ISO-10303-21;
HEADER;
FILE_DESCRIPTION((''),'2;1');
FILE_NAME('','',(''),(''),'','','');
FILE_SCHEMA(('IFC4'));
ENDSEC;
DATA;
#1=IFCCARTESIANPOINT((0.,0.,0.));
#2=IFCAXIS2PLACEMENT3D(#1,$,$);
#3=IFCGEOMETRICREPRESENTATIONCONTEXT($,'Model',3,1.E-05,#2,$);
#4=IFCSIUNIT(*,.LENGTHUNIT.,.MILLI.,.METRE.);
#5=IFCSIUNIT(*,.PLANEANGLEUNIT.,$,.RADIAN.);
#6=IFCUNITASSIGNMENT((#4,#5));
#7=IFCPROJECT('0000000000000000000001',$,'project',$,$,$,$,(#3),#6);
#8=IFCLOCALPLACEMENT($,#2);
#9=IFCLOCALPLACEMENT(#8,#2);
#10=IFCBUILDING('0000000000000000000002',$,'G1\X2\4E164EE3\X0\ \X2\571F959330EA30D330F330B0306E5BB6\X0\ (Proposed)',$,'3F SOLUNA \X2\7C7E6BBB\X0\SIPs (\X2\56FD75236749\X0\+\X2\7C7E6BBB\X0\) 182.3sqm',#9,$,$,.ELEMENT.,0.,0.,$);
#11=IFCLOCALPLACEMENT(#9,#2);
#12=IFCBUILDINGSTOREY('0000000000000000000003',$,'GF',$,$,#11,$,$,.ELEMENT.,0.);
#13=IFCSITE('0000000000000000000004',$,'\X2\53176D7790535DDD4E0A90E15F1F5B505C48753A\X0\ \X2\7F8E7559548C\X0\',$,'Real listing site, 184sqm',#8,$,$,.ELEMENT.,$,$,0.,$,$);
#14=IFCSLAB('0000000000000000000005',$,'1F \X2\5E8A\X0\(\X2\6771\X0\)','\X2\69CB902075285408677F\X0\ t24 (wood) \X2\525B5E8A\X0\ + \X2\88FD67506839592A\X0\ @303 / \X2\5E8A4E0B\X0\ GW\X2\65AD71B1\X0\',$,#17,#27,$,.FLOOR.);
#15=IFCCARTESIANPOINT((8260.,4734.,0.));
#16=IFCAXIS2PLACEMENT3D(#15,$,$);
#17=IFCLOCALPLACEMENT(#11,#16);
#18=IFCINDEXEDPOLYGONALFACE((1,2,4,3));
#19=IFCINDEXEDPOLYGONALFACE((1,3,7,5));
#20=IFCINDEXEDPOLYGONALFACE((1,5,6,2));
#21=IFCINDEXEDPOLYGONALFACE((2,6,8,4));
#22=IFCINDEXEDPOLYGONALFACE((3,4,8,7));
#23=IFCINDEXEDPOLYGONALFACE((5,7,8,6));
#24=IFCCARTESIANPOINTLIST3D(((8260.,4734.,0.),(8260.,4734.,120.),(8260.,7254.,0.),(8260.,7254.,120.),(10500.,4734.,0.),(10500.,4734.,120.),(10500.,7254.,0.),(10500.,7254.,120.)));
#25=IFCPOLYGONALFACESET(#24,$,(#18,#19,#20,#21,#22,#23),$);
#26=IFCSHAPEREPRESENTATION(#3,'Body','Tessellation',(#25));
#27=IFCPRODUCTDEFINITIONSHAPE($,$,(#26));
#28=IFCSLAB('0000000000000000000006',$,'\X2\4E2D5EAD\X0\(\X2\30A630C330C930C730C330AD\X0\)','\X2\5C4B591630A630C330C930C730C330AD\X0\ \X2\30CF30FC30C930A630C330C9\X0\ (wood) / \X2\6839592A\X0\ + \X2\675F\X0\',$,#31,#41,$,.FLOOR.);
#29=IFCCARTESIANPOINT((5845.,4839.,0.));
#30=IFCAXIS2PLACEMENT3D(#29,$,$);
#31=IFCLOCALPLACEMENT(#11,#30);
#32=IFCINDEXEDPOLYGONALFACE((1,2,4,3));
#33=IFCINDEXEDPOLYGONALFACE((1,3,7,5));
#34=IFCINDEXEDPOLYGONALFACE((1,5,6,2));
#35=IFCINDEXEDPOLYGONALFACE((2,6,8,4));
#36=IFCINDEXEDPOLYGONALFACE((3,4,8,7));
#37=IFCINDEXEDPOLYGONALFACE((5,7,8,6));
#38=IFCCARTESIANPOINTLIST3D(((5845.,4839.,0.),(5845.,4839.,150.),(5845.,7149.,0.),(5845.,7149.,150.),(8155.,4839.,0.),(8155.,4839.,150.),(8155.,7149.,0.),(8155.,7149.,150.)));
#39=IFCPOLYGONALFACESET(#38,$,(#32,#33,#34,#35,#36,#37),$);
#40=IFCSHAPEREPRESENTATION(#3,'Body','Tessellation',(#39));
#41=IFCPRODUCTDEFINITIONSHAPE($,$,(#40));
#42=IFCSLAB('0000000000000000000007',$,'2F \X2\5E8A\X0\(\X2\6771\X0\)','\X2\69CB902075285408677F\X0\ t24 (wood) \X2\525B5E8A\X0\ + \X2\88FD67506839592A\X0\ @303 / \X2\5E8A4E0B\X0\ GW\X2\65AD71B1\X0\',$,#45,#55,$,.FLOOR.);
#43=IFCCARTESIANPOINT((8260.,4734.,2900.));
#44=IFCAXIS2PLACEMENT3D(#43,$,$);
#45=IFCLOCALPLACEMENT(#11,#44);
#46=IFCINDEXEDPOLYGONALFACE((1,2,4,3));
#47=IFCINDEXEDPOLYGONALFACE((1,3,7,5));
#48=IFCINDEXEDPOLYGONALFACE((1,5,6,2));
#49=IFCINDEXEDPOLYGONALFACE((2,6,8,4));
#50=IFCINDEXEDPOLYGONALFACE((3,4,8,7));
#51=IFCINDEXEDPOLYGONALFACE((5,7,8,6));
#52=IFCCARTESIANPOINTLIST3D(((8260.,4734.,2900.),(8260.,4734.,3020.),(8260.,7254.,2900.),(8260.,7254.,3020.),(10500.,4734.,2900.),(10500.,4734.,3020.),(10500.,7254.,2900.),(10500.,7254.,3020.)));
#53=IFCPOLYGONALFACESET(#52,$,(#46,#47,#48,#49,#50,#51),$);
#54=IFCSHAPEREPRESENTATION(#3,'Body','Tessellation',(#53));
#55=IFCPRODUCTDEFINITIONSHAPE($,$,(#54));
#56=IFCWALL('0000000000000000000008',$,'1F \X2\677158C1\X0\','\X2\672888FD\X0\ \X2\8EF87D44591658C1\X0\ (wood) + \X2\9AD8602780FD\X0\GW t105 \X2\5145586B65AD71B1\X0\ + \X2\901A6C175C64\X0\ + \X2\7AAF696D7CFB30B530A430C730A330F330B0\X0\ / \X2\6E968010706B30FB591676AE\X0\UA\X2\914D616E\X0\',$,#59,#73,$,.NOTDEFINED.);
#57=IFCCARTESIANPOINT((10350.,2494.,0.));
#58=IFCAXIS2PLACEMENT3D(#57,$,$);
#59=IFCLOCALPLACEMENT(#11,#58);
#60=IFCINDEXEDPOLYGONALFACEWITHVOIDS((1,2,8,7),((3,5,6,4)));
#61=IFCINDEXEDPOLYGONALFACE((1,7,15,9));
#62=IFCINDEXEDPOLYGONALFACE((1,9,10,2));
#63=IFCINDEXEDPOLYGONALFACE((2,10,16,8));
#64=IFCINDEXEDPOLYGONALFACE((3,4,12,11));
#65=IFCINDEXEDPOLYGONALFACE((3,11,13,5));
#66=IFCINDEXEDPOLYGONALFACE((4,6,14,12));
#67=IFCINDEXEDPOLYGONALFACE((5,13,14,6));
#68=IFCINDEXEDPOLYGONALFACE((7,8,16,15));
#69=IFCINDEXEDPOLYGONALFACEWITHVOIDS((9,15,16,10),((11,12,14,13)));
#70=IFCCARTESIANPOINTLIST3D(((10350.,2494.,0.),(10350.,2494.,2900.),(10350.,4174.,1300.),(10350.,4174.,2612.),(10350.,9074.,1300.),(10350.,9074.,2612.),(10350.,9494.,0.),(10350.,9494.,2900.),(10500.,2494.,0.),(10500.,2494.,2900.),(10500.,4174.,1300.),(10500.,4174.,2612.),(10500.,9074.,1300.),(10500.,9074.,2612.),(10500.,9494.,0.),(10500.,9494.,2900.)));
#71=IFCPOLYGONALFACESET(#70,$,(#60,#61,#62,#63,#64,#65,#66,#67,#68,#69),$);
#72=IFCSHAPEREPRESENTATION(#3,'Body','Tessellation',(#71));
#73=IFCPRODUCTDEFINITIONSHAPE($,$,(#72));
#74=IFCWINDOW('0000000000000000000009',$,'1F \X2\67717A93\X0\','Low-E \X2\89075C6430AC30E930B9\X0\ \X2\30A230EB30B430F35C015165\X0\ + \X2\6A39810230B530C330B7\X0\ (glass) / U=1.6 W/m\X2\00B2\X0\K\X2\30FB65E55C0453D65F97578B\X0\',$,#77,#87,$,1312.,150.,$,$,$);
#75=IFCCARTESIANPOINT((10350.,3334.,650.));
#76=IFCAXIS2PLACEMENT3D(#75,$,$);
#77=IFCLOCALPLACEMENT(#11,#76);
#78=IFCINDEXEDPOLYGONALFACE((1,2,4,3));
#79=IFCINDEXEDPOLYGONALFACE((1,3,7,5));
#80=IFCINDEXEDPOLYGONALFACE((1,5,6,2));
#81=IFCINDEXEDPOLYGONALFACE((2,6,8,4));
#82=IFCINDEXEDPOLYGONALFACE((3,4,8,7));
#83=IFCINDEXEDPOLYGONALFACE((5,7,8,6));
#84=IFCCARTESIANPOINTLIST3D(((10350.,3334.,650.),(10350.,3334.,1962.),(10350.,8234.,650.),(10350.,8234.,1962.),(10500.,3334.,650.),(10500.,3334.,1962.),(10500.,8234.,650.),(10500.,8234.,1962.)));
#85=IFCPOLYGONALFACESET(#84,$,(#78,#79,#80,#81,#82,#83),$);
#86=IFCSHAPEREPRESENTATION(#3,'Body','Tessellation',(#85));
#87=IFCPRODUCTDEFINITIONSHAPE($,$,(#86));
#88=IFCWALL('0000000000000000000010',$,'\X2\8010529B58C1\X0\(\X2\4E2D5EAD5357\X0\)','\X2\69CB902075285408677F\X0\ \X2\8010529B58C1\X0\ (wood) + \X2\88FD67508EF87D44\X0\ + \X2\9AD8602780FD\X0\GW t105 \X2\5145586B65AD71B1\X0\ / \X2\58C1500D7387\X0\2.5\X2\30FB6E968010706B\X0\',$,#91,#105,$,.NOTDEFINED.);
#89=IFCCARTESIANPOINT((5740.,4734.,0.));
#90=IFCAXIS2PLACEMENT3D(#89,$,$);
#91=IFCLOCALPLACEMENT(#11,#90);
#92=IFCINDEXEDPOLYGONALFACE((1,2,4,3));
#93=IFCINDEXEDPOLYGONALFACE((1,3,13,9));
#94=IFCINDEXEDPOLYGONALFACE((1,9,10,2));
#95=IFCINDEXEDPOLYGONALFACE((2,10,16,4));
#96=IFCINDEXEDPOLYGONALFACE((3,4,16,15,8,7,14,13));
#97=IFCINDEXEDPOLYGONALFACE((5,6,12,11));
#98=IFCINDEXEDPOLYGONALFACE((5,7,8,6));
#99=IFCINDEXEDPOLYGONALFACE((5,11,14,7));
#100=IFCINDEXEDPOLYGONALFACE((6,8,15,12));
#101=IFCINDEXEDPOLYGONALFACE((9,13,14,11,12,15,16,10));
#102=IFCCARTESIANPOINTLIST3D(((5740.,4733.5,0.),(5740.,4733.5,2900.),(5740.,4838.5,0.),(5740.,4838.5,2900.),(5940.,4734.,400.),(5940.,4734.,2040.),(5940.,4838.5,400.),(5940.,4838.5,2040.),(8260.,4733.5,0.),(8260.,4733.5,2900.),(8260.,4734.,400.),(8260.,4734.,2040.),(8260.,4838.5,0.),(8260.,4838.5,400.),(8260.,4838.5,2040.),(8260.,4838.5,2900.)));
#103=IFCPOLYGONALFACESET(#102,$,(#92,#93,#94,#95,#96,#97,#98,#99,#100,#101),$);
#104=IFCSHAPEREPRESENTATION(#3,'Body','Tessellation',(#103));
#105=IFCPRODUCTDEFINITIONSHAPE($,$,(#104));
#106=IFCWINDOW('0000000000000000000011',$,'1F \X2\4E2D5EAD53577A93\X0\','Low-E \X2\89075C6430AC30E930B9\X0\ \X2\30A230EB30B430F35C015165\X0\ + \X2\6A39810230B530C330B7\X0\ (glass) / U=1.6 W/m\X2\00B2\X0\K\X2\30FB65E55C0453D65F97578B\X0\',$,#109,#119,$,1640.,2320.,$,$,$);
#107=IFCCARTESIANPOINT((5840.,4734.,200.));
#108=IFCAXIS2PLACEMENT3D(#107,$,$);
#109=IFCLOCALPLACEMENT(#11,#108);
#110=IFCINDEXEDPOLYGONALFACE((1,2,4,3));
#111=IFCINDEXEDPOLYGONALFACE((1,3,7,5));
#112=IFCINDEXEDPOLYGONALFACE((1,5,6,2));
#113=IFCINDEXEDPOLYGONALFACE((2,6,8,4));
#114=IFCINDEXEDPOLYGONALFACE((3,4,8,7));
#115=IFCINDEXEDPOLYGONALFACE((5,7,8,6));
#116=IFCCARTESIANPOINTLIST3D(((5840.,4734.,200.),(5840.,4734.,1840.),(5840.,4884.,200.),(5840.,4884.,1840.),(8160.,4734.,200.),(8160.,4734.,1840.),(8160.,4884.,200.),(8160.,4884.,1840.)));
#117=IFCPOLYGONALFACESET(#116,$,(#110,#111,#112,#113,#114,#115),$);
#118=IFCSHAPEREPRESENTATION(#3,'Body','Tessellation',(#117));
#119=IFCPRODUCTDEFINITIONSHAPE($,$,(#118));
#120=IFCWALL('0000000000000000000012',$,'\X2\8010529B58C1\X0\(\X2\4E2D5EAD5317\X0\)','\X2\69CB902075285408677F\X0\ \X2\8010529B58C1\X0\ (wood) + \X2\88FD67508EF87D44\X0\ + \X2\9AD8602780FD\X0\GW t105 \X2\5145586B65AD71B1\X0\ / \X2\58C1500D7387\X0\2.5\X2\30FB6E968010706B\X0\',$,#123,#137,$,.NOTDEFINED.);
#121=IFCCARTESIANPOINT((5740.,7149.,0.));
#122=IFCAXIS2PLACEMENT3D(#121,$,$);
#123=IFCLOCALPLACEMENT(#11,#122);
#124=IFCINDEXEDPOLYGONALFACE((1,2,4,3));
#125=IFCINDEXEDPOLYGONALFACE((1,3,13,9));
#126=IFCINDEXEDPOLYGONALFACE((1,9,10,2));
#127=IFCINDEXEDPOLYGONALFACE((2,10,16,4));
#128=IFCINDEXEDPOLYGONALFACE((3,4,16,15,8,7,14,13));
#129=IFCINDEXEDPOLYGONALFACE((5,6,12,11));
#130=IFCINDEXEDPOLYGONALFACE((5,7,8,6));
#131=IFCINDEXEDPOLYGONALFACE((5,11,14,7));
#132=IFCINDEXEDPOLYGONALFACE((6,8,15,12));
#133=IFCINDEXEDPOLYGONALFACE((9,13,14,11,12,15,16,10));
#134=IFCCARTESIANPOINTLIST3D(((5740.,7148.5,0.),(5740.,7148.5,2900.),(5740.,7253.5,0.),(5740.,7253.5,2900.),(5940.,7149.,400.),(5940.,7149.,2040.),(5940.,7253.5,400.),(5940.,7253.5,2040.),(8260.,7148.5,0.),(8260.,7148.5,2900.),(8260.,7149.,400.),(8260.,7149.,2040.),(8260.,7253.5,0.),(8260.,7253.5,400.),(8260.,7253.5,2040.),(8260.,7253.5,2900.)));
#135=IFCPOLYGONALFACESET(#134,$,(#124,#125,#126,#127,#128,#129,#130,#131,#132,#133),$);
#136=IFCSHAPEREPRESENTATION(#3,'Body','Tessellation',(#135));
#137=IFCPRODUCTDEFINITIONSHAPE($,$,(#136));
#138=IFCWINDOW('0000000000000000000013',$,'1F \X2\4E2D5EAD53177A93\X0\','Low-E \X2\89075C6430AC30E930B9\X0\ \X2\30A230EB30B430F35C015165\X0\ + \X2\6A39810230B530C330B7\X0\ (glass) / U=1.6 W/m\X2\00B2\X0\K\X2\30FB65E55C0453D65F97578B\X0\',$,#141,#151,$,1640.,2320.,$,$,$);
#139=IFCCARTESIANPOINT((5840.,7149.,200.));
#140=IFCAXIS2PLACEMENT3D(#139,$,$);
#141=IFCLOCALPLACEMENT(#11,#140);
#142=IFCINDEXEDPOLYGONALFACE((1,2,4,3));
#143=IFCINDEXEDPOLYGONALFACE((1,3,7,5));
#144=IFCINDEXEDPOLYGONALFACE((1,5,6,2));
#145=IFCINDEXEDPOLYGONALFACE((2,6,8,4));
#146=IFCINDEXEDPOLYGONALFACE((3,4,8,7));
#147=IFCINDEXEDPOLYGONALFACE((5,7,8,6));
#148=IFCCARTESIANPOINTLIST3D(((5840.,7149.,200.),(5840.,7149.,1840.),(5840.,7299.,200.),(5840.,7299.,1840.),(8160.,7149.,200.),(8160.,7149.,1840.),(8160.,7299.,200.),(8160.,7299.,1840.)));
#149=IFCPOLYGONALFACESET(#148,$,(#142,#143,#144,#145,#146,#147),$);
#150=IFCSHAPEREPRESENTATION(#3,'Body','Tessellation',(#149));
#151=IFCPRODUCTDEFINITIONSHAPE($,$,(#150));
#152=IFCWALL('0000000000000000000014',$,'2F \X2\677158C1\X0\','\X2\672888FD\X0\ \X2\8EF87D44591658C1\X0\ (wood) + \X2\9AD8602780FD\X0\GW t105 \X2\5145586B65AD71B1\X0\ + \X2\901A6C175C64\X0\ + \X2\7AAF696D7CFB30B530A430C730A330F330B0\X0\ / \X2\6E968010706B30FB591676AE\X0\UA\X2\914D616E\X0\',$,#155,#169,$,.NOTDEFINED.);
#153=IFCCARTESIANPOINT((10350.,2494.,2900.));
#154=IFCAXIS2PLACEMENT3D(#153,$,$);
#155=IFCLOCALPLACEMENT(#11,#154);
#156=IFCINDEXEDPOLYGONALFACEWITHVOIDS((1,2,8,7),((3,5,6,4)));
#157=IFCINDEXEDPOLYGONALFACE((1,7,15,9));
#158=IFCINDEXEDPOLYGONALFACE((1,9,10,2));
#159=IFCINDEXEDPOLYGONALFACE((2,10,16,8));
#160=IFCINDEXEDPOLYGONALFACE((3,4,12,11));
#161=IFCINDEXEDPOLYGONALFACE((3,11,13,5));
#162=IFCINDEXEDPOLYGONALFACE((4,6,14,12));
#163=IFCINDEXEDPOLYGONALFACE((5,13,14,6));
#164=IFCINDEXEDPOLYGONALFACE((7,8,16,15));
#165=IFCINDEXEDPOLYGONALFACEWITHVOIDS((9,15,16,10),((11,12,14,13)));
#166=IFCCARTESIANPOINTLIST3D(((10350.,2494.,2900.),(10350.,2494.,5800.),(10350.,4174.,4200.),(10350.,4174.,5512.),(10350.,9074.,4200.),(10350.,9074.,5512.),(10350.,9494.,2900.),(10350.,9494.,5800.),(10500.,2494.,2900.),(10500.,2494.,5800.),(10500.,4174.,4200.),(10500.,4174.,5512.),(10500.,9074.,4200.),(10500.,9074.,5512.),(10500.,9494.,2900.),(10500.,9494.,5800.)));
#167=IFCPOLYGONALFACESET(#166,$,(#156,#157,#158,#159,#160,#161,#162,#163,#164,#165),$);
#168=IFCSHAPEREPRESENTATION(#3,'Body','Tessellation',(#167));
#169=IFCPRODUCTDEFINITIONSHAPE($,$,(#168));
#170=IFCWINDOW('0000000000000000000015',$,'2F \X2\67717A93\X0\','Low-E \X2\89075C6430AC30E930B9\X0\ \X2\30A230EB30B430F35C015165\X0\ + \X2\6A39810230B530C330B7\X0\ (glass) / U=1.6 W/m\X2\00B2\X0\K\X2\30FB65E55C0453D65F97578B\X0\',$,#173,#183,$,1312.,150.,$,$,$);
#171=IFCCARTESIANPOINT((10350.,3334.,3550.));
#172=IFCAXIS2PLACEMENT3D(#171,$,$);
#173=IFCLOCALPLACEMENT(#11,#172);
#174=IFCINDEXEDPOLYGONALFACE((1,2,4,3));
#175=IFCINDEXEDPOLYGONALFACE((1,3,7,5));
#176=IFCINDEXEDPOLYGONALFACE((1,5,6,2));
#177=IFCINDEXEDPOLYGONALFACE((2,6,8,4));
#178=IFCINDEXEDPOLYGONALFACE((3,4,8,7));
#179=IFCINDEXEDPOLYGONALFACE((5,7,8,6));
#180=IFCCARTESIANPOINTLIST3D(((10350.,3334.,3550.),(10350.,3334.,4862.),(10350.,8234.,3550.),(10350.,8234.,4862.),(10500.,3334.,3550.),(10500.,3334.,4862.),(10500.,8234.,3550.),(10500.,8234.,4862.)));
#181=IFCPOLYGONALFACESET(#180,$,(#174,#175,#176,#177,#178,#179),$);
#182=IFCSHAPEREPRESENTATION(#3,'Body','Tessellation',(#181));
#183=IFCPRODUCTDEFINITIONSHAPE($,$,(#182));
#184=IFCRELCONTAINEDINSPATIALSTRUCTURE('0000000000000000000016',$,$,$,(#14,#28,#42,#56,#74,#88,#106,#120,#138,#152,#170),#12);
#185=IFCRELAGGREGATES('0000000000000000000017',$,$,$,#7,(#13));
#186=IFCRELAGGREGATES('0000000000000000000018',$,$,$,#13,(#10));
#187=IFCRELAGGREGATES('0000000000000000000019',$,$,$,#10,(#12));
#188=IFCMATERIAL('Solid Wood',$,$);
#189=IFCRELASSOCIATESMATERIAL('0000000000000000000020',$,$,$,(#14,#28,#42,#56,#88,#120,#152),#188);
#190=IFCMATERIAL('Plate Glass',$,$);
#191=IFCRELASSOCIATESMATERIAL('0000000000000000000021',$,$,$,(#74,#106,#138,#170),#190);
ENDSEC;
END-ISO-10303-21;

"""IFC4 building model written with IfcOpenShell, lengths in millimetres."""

from ifc_helpers import new_model, si_unit, frame, frame_2d, origin, place, context, project, spatial, rectangle, extrude, material, element, fill, save


model = new_model("IFC4")

# Units and contexts
model_context = context("Model", 3, precision=1e-05, world=origin())
ifc_project = project(units=[si_unit("LENGTHUNIT", "METRE", prefix="MILLI"), si_unit("PLANEANGLEUNIT", "RADIAN")], contexts=[model_context])

# Site, building, storey
site_placement = place(None, origin())
site = spatial("IfcSite", under=ifc_project, at=site_placement, Name="北海道川上郡弟子屈町 美留和", ObjectType="Real listing site, 184sqm", CompositionType="ELEMENT", RefElevation=0.0)
building_placement = place(site_placement, origin())
building = spatial("IfcBuilding", under=site, at=building_placement, Name="G1世代 土間リビングの家 (Proposed)", ObjectType="3F SOLUNA 籾殻SIPs (国産杉+籾殻) 182.3sqm", CompositionType="ELEMENT", ElevationOfRefHeight=0.0, ElevationOfTerrain=0.0)
storey_placement = place(building_placement, origin())
storey = spatial("IfcBuildingStorey", under=building, at=storey_placement, Name="GF", CompositionType="ELEMENT", Elevation=0.0)

# Slabs
ifc_material_1 = material(Name="Solid Wood")
slab_1_placement = place(storey_placement, frame((8260.0, 4734.0, 0.0)))
element("IfcSlab", 1, at=slab_1_placement, inside=storey, material=ifc_material_1, Name="1F 床(東)", Description="構造用合板 t24 (wood) 剛床 + 製材根太 @303 / 床下 GW断熱", PredefinedType="FLOOR", context=model_context, shape_type="SweptSolid", body=[
    extrude(rectangle(XDim=2240.0, YDim=2520.0, at=frame_2d((1120.0, 1260.0))), frame((8260.0, 4734.0, 0.0)), (0.0, 0.0, 1.0), 120.0),
])
slab_2_placement = place(storey_placement, frame((5845.0, 4839.0, 0.0)))
element("IfcSlab", 2, at=slab_2_placement, inside=storey, material=ifc_material_1, Name="中庭(ウッドデッキ)", Description="屋外ウッドデッキ ハードウッド (wood) / 根太 + 束", PredefinedType="FLOOR", context=model_context, shape_type="SweptSolid", body=[
    extrude(rectangle(XDim=2310.0, YDim=2310.0, at=frame_2d((1155.0, 1155.0))), frame((5845.0, 4839.0, 0.0)), (0.0, 0.0, 1.0), 150.0),
])
slab_3_placement = place(storey_placement, frame((8260.0, 4734.0, 2900.0)))
element("IfcSlab", 3, at=slab_3_placement, inside=storey, material=ifc_material_1, Name="2F 床(東)", Description="構造用合板 t24 (wood) 剛床 + 製材根太 @303 / 床下 GW断熱", PredefinedType="FLOOR", context=model_context, shape_type="SweptSolid", body=[
    extrude(rectangle(XDim=2240.0, YDim=2520.0, at=frame_2d((1120.0, 1260.0))), frame((8260.0, 4734.0, 2900.0)), (0.0, 0.0, 1.0), 120.0),
])

# Walls, openings, windows
wall_1_placement = place(storey_placement, frame((10350.0, 2494.0, 0.0)))
wall_1 = element("IfcWall", 4, at=wall_1_placement, inside=storey, material=ifc_material_1, Name="1F 東壁", Description="木製 軸組外壁 (wood) + 高性能GW t105 充填断熱 + 通気層 + 窯業系サイディング / 準耐火・外皮UA配慮", PredefinedType="NOTDEFINED", context=model_context, shape_type="SweptSolid", body=[
    extrude(rectangle(XDim=150.0, YDim=7000.0, at=frame_2d((75.0, 3500.0))), frame((10350.0, 2494.0, 0.0)), (0.0, 0.0, 1.0), 2900.0),
])
opening_1_placement = place(storey_placement, frame((10350.0, 3334.0, 650.0)))
opening_1 = element("IfcOpeningElement", 5, at=opening_1_placement, cuts=wall_1, PredefinedType="NOTDEFINED", context=model_context, shape_type="SweptSolid", body=[
    extrude(rectangle(XDim=150.0, YDim=4900.0, at=frame_2d((75.0, 2450.0))), frame((10350.0, 3334.0, 650.0)), (0.0, 0.0, 1.0), 1312.0),
])
ifc_material_2 = material(Name="Plate Glass")
window_1_placement = place(storey_placement, frame((10350.0, 3334.0, 650.0)))
window_1 = element("IfcWindow", 6, at=window_1_placement, inside=storey, material=ifc_material_2, Name="1F 東窓", Description="Low-E 複層ガラス アルゴン封入 + 樹脂サッシ (glass) / U=1.6 W/m²K・日射取得型", OverallHeight=1312.0, OverallWidth=150.0, context=model_context, shape_type="SweptSolid", body=[
    extrude(rectangle(XDim=150.0, YDim=4900.0, at=frame_2d((75.0, 2450.0))), frame((10350.0, 3334.0, 650.0)), (0.0, 0.0, 1.0), 1312.0),
])
fill(opening_1, window_1)
wall_2_placement = place(storey_placement, frame((5740.0, 4734.0, 0.0)))
wall_2 = element("IfcWall", 7, at=wall_2_placement, inside=storey, material=ifc_material_1, Name="耐力壁(中庭南)", Description="構造用合板 耐力壁 (wood) + 製材軸組 + 高性能GW t105 充填断熱 / 壁倍率2.5・準耐火", PredefinedType="NOTDEFINED", context=model_context, shape_type="SweptSolid", body=[
    extrude(rectangle(XDim=2520.0, YDim=105.0, at=frame_2d((1260.0, 52.0))), frame((5740.0, 4734.0, 0.0)), (0.0, 0.0, 1.0), 2900.0),
])
opening_2_placement = place(storey_placement, frame((5840.0, 4734.0, 200.0)))
opening_2 = element("IfcOpeningElement", 8, at=opening_2_placement, cuts=wall_2, PredefinedType="NOTDEFINED", context=model_context, shape_type="SweptSolid", body=[
    extrude(rectangle(XDim=2320.0, YDim=150.0, at=frame_2d((1160.0, 75.0))), frame((5840.0, 4734.0, 200.0)), (0.0, 0.0, 1.0), 1640.0),
])
window_2_placement = place(storey_placement, frame((5840.0, 4734.0, 200.0)))
window_2 = element("IfcWindow", 9, at=window_2_placement, inside=storey, material=ifc_material_2, Name="1F 中庭南窓", Description="Low-E 複層ガラス アルゴン封入 + 樹脂サッシ (glass) / U=1.6 W/m²K・日射取得型", OverallHeight=1640.0, OverallWidth=2320.0, context=model_context, shape_type="SweptSolid", body=[
    extrude(rectangle(XDim=2320.0, YDim=150.0, at=frame_2d((1160.0, 75.0))), frame((5840.0, 4734.0, 200.0)), (0.0, 0.0, 1.0), 1640.0),
])
fill(opening_2, window_2)
wall_3_placement = place(storey_placement, frame((5740.0, 7149.0, 0.0)))
wall_3 = element("IfcWall", 10, at=wall_3_placement, inside=storey, material=ifc_material_1, Name="耐力壁(中庭北)", Description="構造用合板 耐力壁 (wood) + 製材軸組 + 高性能GW t105 充填断熱 / 壁倍率2.5・準耐火", PredefinedType="NOTDEFINED", context=model_context, shape_type="SweptSolid", body=[
    extrude(rectangle(XDim=2520.0, YDim=105.0, at=frame_2d((1260.0, 52.0))), frame((5740.0, 7149.0, 0.0)), (0.0, 0.0, 1.0), 2900.0),
])
opening_3_placement = place(storey_placement, frame((5840.0, 7149.0, 200.0)))
opening_3 = element("IfcOpeningElement", 11, at=opening_3_placement, cuts=wall_3, PredefinedType="NOTDEFINED", context=model_context, shape_type="SweptSolid", body=[
    extrude(rectangle(XDim=2320.0, YDim=150.0, at=frame_2d((1160.0, 75.0))), frame((5840.0, 7149.0, 200.0)), (0.0, 0.0, 1.0), 1640.0),
])
window_3_placement = place(storey_placement, frame((5840.0, 7149.0, 200.0)))
window_3 = element("IfcWindow", 12, at=window_3_placement, inside=storey, material=ifc_material_2, Name="1F 中庭北窓", Description="Low-E 複層ガラス アルゴン封入 + 樹脂サッシ (glass) / U=1.6 W/m²K・日射取得型", OverallHeight=1640.0, OverallWidth=2320.0, context=model_context, shape_type="SweptSolid", body=[
    extrude(rectangle(XDim=2320.0, YDim=150.0, at=frame_2d((1160.0, 75.0))), frame((5840.0, 7149.0, 200.0)), (0.0, 0.0, 1.0), 1640.0),
])
fill(opening_3, window_3)

# Wall, opening, window
wall_4_placement = place(storey_placement, frame((10350.0, 2494.0, 2900.0)))
wall_4 = element("IfcWall", 13, at=wall_4_placement, inside=storey, material=ifc_material_1, Name="2F 東壁", Description="木製 軸組外壁 (wood) + 高性能GW t105 充填断熱 + 通気層 + 窯業系サイディング / 準耐火・外皮UA配慮", PredefinedType="NOTDEFINED", context=model_context, shape_type="SweptSolid", body=[
    extrude(rectangle(XDim=150.0, YDim=7000.0, at=frame_2d((75.0, 3500.0))), frame((10350.0, 2494.0, 2900.0)), (0.0, 0.0, 1.0), 2900.0),
])
opening_4_placement = place(storey_placement, frame((10350.0, 3334.0, 3550.0)))
opening_4 = element("IfcOpeningElement", 14, at=opening_4_placement, cuts=wall_4, PredefinedType="NOTDEFINED", context=model_context, shape_type="SweptSolid", body=[
    extrude(rectangle(XDim=150.0, YDim=4900.0, at=frame_2d((75.0, 2450.0))), frame((10350.0, 3334.0, 3550.0)), (0.0, 0.0, 1.0), 1312.0),
])
window_4_placement = place(storey_placement, frame((10350.0, 3334.0, 3550.0)))
window_4 = element("IfcWindow", 15, at=window_4_placement, inside=storey, material=ifc_material_2, Name="2F 東窓", Description="Low-E 複層ガラス アルゴン封入 + 樹脂サッシ (glass) / U=1.6 W/m²K・日射取得型", OverallHeight=1312.0, OverallWidth=150.0, context=model_context, shape_type="SweptSolid", body=[
    extrude(rectangle(XDim=150.0, YDim=4900.0, at=frame_2d((75.0, 2450.0))), frame((10350.0, 3334.0, 3550.0)), (0.0, 0.0, 1.0), 1312.0),
])
fill(opening_4, window_4)

save(model, "model.ifc")
